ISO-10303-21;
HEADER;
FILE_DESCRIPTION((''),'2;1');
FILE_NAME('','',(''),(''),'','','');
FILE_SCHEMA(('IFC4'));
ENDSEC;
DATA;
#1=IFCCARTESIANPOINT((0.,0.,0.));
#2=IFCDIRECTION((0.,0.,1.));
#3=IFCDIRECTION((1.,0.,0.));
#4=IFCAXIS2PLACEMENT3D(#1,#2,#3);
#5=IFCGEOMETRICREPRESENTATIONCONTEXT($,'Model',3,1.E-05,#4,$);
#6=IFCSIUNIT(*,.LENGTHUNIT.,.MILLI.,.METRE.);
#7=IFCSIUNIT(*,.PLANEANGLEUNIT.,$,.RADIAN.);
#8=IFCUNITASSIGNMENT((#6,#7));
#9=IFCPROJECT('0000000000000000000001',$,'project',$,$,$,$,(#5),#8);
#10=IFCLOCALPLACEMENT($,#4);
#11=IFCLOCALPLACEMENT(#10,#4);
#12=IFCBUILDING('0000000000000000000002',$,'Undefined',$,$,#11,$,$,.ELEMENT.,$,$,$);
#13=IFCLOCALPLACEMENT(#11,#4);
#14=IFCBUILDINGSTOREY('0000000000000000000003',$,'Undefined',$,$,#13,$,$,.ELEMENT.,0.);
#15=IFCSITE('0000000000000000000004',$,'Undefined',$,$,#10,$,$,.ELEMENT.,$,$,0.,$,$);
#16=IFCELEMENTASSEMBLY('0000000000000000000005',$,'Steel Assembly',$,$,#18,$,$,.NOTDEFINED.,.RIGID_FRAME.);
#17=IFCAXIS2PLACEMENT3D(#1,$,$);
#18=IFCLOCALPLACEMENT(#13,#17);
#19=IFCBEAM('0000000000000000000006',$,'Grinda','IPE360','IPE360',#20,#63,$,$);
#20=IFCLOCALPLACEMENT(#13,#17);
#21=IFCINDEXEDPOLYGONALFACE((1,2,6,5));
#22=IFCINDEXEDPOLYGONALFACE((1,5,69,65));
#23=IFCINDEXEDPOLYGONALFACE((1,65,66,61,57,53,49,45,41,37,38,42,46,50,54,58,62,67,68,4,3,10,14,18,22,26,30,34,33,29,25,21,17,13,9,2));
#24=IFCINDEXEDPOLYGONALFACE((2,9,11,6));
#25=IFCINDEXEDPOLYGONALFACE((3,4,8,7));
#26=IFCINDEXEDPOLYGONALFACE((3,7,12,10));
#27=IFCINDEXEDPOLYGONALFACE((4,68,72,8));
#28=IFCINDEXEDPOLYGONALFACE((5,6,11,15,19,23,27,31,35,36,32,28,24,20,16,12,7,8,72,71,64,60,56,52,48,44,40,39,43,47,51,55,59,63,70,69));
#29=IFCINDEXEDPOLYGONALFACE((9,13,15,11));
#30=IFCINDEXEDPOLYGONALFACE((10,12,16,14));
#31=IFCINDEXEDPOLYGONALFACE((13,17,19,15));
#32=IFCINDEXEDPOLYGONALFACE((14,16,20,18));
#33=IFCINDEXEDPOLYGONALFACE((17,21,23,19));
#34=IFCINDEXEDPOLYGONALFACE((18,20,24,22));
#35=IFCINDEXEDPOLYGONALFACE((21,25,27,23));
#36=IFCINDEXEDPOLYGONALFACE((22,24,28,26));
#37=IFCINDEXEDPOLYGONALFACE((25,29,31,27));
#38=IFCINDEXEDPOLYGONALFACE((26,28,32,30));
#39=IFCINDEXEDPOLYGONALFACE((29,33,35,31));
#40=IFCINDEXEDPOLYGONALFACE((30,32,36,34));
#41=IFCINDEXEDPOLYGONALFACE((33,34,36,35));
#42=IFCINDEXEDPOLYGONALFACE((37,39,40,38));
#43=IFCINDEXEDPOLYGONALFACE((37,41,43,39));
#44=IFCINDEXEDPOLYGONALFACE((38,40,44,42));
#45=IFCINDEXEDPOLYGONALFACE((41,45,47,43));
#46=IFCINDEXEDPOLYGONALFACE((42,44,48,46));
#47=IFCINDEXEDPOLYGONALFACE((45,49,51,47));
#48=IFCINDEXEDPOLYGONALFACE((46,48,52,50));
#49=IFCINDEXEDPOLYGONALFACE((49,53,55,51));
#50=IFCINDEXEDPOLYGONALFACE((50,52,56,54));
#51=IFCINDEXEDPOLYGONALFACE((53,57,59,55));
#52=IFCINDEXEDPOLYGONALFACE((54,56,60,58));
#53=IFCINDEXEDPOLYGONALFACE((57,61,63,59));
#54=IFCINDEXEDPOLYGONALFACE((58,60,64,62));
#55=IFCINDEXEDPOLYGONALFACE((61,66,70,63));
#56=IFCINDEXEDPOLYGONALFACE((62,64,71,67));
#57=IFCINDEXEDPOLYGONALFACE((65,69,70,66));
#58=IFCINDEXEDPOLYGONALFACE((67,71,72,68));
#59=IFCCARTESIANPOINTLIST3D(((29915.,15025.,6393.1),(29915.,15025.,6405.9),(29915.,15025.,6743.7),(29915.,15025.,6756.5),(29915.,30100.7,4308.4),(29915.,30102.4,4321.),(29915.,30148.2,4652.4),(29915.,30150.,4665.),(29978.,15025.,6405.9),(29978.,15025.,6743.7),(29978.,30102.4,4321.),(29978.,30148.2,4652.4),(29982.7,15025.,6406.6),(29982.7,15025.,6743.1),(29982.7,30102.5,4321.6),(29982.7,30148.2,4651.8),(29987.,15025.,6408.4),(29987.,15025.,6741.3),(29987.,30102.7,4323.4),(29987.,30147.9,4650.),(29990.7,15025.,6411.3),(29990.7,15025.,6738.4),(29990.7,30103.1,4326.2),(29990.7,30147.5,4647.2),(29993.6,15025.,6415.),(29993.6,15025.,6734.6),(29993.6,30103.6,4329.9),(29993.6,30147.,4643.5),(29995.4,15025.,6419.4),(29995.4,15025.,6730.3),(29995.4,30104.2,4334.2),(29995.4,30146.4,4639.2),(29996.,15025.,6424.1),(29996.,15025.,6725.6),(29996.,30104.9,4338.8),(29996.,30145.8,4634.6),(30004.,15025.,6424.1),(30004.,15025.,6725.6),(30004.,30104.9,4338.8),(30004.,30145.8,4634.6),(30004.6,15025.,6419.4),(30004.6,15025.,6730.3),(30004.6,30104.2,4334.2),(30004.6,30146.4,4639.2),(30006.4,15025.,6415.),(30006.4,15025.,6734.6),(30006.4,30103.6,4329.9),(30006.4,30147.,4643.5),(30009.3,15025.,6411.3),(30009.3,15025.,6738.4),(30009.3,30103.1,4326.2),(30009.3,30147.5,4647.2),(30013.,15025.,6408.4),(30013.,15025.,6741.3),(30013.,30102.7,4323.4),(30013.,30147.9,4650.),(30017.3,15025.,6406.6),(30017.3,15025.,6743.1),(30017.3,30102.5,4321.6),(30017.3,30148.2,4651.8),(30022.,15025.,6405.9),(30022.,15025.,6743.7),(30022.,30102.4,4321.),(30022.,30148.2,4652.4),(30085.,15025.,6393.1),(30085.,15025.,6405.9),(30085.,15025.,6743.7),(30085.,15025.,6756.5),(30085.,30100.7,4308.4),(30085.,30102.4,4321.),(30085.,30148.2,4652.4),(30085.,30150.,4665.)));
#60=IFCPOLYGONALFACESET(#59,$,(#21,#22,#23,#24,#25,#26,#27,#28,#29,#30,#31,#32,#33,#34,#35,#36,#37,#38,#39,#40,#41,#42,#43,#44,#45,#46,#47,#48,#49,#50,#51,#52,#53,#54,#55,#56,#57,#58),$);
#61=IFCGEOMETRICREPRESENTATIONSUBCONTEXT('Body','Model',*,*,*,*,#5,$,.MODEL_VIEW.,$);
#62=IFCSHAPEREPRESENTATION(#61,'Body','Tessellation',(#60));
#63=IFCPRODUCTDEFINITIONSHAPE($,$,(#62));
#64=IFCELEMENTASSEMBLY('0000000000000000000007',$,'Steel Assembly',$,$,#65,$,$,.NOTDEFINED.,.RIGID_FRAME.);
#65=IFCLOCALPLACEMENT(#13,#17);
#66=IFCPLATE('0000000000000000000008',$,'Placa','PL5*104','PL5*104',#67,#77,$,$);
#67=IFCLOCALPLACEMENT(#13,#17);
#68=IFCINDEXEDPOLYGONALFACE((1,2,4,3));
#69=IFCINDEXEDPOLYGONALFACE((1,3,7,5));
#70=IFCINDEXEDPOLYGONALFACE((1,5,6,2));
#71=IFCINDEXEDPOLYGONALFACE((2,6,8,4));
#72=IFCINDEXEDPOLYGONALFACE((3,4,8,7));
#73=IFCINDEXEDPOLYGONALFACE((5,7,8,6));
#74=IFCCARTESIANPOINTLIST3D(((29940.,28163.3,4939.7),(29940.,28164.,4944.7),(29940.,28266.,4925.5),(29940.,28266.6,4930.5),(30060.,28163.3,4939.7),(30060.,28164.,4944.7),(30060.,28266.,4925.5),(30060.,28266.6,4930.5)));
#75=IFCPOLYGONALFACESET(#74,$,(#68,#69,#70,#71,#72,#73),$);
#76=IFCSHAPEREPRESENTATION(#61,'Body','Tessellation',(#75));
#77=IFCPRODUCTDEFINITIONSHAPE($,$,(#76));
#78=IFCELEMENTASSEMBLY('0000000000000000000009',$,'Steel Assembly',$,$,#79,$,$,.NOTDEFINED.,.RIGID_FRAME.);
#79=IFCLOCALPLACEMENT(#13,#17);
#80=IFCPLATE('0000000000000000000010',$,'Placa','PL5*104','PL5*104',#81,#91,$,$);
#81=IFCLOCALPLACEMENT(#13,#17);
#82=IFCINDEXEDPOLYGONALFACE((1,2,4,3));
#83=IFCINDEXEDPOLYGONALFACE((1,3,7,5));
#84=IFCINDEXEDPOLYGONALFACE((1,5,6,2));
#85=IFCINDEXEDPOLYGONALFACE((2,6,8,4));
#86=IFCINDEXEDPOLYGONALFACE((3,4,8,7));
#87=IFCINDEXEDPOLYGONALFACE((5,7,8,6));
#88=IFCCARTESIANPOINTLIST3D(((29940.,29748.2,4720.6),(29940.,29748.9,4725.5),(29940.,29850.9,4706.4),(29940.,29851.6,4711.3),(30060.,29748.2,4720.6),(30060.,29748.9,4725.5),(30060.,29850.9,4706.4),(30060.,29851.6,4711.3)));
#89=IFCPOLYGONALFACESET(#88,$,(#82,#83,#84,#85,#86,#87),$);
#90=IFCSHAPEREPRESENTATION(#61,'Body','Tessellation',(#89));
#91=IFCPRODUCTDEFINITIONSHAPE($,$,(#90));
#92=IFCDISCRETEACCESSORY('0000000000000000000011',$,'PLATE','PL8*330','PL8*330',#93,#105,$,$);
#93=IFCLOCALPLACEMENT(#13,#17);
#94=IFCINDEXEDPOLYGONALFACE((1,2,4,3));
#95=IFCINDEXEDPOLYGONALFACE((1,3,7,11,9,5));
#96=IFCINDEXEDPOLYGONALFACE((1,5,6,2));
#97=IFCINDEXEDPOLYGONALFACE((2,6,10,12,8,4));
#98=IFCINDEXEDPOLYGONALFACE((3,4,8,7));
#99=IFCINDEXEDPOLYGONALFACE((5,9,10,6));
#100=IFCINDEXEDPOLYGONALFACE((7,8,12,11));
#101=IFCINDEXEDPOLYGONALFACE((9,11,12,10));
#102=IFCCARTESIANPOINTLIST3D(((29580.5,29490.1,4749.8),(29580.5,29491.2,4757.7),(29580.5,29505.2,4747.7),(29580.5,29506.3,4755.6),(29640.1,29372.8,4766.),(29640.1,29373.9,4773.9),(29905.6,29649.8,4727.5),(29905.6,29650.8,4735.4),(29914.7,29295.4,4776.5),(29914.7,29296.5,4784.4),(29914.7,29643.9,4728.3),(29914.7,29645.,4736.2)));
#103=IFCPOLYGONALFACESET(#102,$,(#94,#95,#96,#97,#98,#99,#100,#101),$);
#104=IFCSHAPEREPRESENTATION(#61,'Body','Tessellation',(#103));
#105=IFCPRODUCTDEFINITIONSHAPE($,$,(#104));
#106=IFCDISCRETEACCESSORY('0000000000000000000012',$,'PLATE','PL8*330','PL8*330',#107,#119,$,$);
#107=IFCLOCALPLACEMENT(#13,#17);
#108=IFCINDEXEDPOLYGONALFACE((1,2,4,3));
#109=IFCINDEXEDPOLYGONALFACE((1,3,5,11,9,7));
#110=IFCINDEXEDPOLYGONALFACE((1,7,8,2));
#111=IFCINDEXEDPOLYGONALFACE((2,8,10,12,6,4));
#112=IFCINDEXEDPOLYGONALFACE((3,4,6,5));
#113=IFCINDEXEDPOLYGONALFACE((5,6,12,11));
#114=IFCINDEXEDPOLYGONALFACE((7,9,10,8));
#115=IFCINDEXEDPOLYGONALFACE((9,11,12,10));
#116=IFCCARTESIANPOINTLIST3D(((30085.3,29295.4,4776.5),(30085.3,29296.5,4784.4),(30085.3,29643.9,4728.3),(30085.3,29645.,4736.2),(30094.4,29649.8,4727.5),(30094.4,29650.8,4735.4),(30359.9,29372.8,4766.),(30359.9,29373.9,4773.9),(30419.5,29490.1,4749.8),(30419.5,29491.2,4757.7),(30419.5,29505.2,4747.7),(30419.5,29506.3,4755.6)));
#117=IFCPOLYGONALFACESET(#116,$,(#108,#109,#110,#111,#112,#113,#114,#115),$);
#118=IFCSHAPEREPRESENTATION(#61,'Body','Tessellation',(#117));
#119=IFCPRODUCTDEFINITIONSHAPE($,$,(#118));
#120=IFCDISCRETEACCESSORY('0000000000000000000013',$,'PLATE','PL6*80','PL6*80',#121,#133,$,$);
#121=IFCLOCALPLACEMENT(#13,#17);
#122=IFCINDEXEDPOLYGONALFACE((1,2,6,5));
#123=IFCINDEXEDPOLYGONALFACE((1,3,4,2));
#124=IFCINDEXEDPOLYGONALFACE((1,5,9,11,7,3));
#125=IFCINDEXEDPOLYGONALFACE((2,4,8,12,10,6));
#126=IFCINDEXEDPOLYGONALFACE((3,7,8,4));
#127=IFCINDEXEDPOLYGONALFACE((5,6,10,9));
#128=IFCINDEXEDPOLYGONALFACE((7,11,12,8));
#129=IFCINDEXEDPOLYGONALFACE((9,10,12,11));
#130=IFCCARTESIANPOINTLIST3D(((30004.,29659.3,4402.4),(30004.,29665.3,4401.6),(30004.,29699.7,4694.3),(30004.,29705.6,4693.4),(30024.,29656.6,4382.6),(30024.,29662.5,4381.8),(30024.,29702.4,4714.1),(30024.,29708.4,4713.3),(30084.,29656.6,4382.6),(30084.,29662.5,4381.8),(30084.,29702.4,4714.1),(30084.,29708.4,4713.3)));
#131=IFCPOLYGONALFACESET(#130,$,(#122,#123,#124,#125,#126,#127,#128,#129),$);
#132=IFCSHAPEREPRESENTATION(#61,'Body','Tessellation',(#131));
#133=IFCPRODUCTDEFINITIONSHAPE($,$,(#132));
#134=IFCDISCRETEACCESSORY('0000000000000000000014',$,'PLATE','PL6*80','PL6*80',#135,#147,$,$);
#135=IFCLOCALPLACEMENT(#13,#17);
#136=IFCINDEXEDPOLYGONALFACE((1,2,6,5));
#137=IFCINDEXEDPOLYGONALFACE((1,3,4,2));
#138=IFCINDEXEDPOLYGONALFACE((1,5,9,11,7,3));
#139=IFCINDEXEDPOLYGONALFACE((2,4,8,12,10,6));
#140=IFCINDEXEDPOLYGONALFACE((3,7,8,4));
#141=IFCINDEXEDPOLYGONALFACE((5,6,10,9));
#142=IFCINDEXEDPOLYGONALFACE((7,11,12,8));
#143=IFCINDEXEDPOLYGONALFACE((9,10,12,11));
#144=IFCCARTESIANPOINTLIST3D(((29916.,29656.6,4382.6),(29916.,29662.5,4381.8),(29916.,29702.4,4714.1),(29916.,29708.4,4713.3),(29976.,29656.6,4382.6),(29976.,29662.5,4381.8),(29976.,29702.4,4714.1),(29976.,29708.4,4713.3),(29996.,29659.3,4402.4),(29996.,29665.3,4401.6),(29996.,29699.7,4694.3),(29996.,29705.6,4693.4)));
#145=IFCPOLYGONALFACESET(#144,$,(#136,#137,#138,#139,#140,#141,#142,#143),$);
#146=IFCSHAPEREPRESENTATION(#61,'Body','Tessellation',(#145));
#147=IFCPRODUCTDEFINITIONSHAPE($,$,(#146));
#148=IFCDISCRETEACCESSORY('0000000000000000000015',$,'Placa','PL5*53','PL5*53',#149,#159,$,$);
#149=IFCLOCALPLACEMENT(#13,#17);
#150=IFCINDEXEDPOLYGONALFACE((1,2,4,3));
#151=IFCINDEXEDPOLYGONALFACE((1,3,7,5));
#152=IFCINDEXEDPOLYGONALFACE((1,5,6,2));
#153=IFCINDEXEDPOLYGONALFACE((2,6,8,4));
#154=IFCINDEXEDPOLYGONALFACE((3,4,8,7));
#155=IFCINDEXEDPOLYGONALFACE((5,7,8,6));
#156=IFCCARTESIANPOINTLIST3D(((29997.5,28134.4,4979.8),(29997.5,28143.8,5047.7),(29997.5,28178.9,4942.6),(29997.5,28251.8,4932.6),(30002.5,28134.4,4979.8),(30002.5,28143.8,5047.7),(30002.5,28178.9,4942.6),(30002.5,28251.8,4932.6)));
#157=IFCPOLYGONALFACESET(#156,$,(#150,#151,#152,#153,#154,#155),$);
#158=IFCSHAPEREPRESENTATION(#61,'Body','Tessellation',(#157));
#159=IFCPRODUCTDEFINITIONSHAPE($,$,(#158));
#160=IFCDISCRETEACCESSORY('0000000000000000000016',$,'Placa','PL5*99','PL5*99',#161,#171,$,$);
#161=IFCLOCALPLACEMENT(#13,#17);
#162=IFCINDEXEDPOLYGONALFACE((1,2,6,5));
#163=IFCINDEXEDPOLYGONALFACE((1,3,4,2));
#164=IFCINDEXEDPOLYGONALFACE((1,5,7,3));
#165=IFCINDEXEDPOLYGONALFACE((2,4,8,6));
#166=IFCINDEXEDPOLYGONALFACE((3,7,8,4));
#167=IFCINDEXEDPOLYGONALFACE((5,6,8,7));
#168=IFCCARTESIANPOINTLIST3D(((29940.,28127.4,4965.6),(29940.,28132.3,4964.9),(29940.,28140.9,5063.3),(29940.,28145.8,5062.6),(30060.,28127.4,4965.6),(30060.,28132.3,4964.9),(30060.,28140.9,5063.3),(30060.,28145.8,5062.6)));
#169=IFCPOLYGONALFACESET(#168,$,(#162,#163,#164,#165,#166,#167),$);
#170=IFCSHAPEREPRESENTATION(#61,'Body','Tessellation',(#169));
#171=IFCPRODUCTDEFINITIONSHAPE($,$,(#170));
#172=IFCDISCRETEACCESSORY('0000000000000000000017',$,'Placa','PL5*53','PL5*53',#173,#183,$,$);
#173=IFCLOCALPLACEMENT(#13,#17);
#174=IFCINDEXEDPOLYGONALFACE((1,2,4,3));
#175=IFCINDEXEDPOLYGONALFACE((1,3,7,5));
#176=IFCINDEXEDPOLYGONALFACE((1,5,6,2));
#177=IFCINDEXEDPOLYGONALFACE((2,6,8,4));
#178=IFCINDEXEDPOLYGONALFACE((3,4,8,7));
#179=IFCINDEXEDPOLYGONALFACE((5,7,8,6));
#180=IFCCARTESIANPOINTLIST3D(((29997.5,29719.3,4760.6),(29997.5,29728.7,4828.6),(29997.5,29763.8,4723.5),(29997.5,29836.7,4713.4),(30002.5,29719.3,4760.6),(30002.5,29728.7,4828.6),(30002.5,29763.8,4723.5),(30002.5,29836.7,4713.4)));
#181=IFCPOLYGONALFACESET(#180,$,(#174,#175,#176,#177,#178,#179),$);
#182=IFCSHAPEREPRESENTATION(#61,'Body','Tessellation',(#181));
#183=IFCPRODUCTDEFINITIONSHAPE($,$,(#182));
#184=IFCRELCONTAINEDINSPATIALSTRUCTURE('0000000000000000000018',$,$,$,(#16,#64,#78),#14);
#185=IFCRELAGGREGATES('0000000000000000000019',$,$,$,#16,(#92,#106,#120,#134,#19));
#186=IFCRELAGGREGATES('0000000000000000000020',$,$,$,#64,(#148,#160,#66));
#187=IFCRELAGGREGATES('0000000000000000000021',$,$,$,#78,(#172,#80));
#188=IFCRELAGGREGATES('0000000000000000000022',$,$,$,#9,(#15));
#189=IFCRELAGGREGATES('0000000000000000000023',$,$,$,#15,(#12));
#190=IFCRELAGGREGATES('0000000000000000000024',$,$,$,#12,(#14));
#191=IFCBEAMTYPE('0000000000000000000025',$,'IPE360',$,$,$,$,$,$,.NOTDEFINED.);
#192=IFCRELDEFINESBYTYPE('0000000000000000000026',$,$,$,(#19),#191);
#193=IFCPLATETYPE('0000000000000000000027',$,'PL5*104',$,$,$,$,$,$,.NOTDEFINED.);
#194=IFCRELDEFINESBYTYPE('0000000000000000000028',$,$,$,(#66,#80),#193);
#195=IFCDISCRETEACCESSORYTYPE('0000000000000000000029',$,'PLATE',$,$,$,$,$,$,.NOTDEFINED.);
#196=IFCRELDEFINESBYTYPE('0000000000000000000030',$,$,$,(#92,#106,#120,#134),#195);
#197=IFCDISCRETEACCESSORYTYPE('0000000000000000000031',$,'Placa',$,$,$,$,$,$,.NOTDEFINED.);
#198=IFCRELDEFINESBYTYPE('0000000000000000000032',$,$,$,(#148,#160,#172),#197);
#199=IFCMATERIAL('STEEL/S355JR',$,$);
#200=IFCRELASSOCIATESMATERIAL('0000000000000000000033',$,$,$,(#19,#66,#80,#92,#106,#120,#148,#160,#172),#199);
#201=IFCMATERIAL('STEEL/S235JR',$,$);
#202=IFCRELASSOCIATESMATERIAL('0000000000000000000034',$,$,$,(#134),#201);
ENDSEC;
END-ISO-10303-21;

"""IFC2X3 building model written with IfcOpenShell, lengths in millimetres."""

from ifc_helpers import new_model, si_unit, frame, origin_with_axes, origin_2d_with_axis, place, context, subcontext, project, spatial, polyline, i_section, outline, extrude, clip, halfspace, material, type_object, element, aggregate, save


model = new_model("IFC2X3")

# Units and contexts
model_context = context("Model", 3, precision=1e-05, world=origin_with_axes())
body_context = subcontext(model_context, "Body", "Model", "MODEL_VIEW")
ifc_project = project(units=[si_unit("LENGTHUNIT", "METRE", prefix="MILLI"), si_unit("PLANEANGLEUNIT", "RADIAN")], contexts=[model_context])

# Site, building, storey
site_placement = place(None, origin_with_axes())
site = spatial("IfcSite", under=ifc_project, at=site_placement, Name="Undefined", CompositionType="ELEMENT", RefElevation=0.0)
building_placement = place(site_placement, origin_with_axes())
building = spatial("IfcBuilding", under=site, at=building_placement, Name="Undefined", CompositionType="ELEMENT")
storey_placement = place(building_placement, origin_with_axes())
storey = spatial("IfcBuildingStorey", under=building, at=storey_placement, Name="Undefined", CompositionType="ELEMENT", Elevation=0.0)

# Element assembly, beam
ifc_material_1 = material(Name="STEEL/S355JR")
assembly_1_placement = place(storey_placement, origin_with_axes())
assembly_1 = element("IfcElementAssembly", 1, at=assembly_1_placement, inside=storey, Name="Steel Assembly", AssemblyPlace="NOTDEFINED", PredefinedType="RIGID_FRAME")
beam_type_1 = type_object("IfcBeamType", Name="IPE360", PredefinedType="NOTDEFINED")
beam_1_placement = place(assembly_1_placement, frame((30000.0, 30125.3, 4486.7), z_axis=(0.0, 0.13698, 0.990574), x_axis=(0.0, -0.990574, 0.13698)))
beam_1 = element("IfcBeam", 2, at=beam_1_placement, type_object=beam_type_1, material=ifc_material_1, Name="Grinda", Description="IPE360", ObjectType="IPE360", context=body_context, shape_type="Clipping", body=[
    clip(extrude(i_section(OverallWidth=170.0, OverallDepth=360.0, WebThickness=8.0, FlangeThickness=12.7, FilletRadius=18.0, at=origin_2d_with_axis()), frame((15318.5, 0.0, 0.0), z_axis=(-1.0, 0.0, 0.0), x_axis=(0.0, -1.0, 0.0)), (0.0, 0.0, 1.0), 15318.5), halfspace(frame((15271.5, 0.0, 198.3), z_axis=(0.990574, 0.0, -0.13698), x_axis=(0.0, 1.0, 0.0)), False)),
])

# Element assemblies, plates
assembly_2_placement = place(storey_placement, origin_with_axes())
assembly_2 = element("IfcElementAssembly", 3, at=assembly_2_placement, inside=storey, Name="Steel Assembly", AssemblyPlace="NOTDEFINED", PredefinedType="RIGID_FRAME")
plate_type = type_object("IfcPlateType", Name="PL5*104", PredefinedType="NOTDEFINED")
plate_1_placement = place(assembly_2_placement, frame((29940.0, 28163.7, 4942.2), z_axis=(0.0, -0.136905, -0.990584), x_axis=(0.0, 0.990584, -0.136905)))
plate_1 = element("IfcPlate", 4, at=plate_1_placement, type_object=plate_type, material=ifc_material_1, Name="Placa", Description="PL5*104", ObjectType="PL5*104", context=body_context, shape_type="SweptSolid", body=[
    extrude(outline(polyline([(0.0, 0.0), (103.6, 0.0), (103.6, 120.0), (0.0, 120.0), (0.0, 0.0)])), frame((0.0, 0.0, -2.5), z_axis=(0.0, 0.0, 1.0), x_axis=(1.0, 0.0, 0.0)), (0.0, 0.0, 1.0), 5.0),
])
assembly_3_placement = place(storey_placement, origin_with_axes())
assembly_3 = element("IfcElementAssembly", 5, at=assembly_3_placement, inside=storey, Name="Steel Assembly", AssemblyPlace="NOTDEFINED", PredefinedType="RIGID_FRAME")
plate_2_placement = place(assembly_3_placement, frame((29940.0, 29748.6, 4723.0), z_axis=(0.0, -0.136905, -0.990584), x_axis=(0.0, 0.990584, -0.136905)))
plate_2 = element("IfcPlate", 6, at=plate_2_placement, type_object=plate_type, material=ifc_material_1, Name="Placa", Description="PL5*104", ObjectType="PL5*104", context=body_context, shape_type="SweptSolid", body=[
    extrude(outline(polyline([(0.0, 0.0), (103.6, 0.0), (103.6, 120.0), (0.0, 120.0), (0.0, 0.0)])), frame((0.0, 0.0, -2.5), z_axis=(0.0, 0.0, 1.0), x_axis=(1.0, 0.0, 0.0)), (0.0, 0.0, 1.0), 5.0),
])

# Discrete accessories
discrete_accessory_type_1 = type_object("IfcDiscreteAccessoryType", Name="PLATE")
discrete_accessory_1_placement = place(assembly_1_placement, frame((29914.7, 29295.9, 4780.5), z_axis=(0.000554, 0.13698, 0.990574), x_axis=(0.0, 0.990574, -0.13698)))
discrete_accessory_1 = element("IfcDiscreteAccessory", 7, at=discrete_accessory_1_placement, type_object=discrete_accessory_type_1, material=ifc_material_1, Name="PLATE", Description="PL8*330", ObjectType="PL8*330", context=body_context, shape_type="SweptSolid", body=[
    extrude(outline(polyline([(0.0, 0.0), (351.8, 0.0), (357.7, 9.1), (211.8, 334.2), (196.6, 334.2), (78.2, 274.6), (0.0, 0.0)])), frame((0.0, 0.0, -4.0), z_axis=(0.0, 0.0, 1.0), x_axis=(1.0, 0.0, 0.0)), (0.0, 0.0, 1.0), 8.0),
])
discrete_accessory_2_placement = place(assembly_1_placement, frame((30085.3, 29295.9, 4780.5), z_axis=(0.000554, -0.13698, -0.990574), x_axis=(0.0, 0.990574, -0.13698)))
discrete_accessory_2 = element("IfcDiscreteAccessory", 8, at=discrete_accessory_2_placement, type_object=discrete_accessory_type_1, material=ifc_material_1, Name="PLATE", Description="PL8*330", ObjectType="PL8*330", context=body_context, shape_type="SweptSolid", body=[
    extrude(outline(polyline([(0.0, 0.0), (351.8, 0.0), (357.7, 9.1), (211.8, 334.2), (196.6, 334.2), (78.2, 274.6), (0.0, 0.0)])), frame((0.0, 0.0, -4.0), z_axis=(0.0, 0.0, 1.0), x_axis=(1.0, 0.0, 0.0)), (0.0, 0.0, 1.0), 8.0),
])
discrete_accessory_3_placement = place(assembly_1_placement, frame((30084.0, 29659.6, 4382.2), z_axis=(0.0, 0.990574, -0.13698), x_axis=(-1.0, 0.0, 0.0)))
discrete_accessory_3 = element("IfcDiscreteAccessory", 9, at=discrete_accessory_3_placement, type_object=discrete_accessory_type_1, material=ifc_material_1, Name="PLATE", Description="PL6*80", ObjectType="PL6*80", context=body_context, shape_type="SweptSolid", body=[
    extrude(outline(polyline([(0.0, 0.0), (60.0, 0.0), (80.0, 20.0), (80.0, 314.6), (60.0, 334.6), (0.0, 334.6), (0.0, 0.0)])), frame((0.0, 0.0, -3.0), z_axis=(0.0, 0.0, 1.0), x_axis=(1.0, 0.0, 0.0)), (0.0, 0.0, 1.0), 6.0),
])
ifc_material_2 = material(Name="STEEL/S235JR")
discrete_accessory_4_placement = place(assembly_1_placement, frame((29996.0, 29659.6, 4382.2), z_axis=(0.0, 0.990574, -0.13698), x_axis=(-1.0, 0.0, 0.0)))
discrete_accessory_4 = element("IfcDiscreteAccessory", 10, at=discrete_accessory_4_placement, type_object=discrete_accessory_type_1, material=ifc_material_2, Name="PLATE", Description="PL6*80", ObjectType="PL6*80", context=body_context, shape_type="SweptSolid", body=[
    extrude(outline(polyline([(0.0, 20.0), (20.0, 0.0), (80.0, 0.0), (80.0, 334.6), (20.0, 334.6), (0.0, 314.6), (0.0, 20.0)])), frame((0.0, 0.0, -3.0), z_axis=(0.0, 0.0, 1.0), x_axis=(1.0, 0.0, 0.0)), (0.0, 0.0, 1.0), 6.0),
])
aggregate(assembly_1, [discrete_accessory_1, discrete_accessory_2, discrete_accessory_3, discrete_accessory_4, beam_1])

# Discrete accessories
discrete_accessory_type_2 = type_object("IfcDiscreteAccessoryType", Name="Placa")
discrete_accessory_5_placement = place(assembly_2_placement, frame((30000.0, 28143.8, 5047.7), z_axis=(-1.0, 0.0, 0.0), x_axis=(0.0, 0.684057, -0.729429)))
discrete_accessory_5 = element("IfcDiscreteAccessory", 11, at=discrete_accessory_5_placement, type_object=discrete_accessory_type_2, material=ifc_material_1, Name="Placa", Description="PL5*53", ObjectType="PL5*53", context=body_context, shape_type="SweptSolid", body=[
    extrude(outline(polyline([(0.0, 0.0), (157.9, 0.0), (100.7, 46.3), (43.1, 53.3), (0.0, 0.0)])), frame((0.0, 0.0, -2.5), z_axis=(0.0, 0.0, 1.0), x_axis=(1.0, 0.0, 0.0)), (0.0, 0.0, 1.0), 5.0),
])
discrete_accessory_6_placement = place(assembly_2_placement, frame((29940.0, 28129.9, 4965.2), z_axis=(0.0, 0.990592, -0.136849), x_axis=(0.0, 0.136849, 0.990592)))
discrete_accessory_6 = element("IfcDiscreteAccessory", 12, at=discrete_accessory_6_placement, type_object=discrete_accessory_type_2, material=ifc_material_1, Name="Placa", Description="PL5*99", ObjectType="PL5*99", context=body_context, shape_type="SweptSolid", body=[
    extrude(outline(polyline([(0.0, 0.0), (98.6, 0.0), (98.6, 120.0), (0.0, 120.0), (0.0, 0.0)])), frame((0.0, 0.0, -2.5), z_axis=(0.0, 0.0, 1.0), x_axis=(1.0, 0.0, 0.0)), (0.0, 0.0, 1.0), 5.0),
])
discrete_accessory_7_placement = place(assembly_3_placement, frame((30000.0, 29728.7, 4828.6), z_axis=(-1.0, 0.0, 0.0), x_axis=(0.0, 0.684057, -0.729429)))
discrete_accessory_7 = element("IfcDiscreteAccessory", 13, at=discrete_accessory_7_placement, type_object=discrete_accessory_type_2, material=ifc_material_1, Name="Placa", Description="PL5*53", ObjectType="PL5*53", context=body_context, shape_type="SweptSolid", body=[
    extrude(outline(polyline([(0.0, 0.0), (157.9, 0.0), (100.7, 46.3), (43.1, 53.3), (0.0, 0.0)])), frame((0.0, 0.0, -2.5), z_axis=(0.0, 0.0, 1.0), x_axis=(1.0, 0.0, 0.0)), (0.0, 0.0, 1.0), 5.0),
])

aggregate(assembly_2, [discrete_accessory_5, discrete_accessory_6, plate_1])
aggregate(assembly_3, [discrete_accessory_7, plate_2])

save(model, "model.ifc")
